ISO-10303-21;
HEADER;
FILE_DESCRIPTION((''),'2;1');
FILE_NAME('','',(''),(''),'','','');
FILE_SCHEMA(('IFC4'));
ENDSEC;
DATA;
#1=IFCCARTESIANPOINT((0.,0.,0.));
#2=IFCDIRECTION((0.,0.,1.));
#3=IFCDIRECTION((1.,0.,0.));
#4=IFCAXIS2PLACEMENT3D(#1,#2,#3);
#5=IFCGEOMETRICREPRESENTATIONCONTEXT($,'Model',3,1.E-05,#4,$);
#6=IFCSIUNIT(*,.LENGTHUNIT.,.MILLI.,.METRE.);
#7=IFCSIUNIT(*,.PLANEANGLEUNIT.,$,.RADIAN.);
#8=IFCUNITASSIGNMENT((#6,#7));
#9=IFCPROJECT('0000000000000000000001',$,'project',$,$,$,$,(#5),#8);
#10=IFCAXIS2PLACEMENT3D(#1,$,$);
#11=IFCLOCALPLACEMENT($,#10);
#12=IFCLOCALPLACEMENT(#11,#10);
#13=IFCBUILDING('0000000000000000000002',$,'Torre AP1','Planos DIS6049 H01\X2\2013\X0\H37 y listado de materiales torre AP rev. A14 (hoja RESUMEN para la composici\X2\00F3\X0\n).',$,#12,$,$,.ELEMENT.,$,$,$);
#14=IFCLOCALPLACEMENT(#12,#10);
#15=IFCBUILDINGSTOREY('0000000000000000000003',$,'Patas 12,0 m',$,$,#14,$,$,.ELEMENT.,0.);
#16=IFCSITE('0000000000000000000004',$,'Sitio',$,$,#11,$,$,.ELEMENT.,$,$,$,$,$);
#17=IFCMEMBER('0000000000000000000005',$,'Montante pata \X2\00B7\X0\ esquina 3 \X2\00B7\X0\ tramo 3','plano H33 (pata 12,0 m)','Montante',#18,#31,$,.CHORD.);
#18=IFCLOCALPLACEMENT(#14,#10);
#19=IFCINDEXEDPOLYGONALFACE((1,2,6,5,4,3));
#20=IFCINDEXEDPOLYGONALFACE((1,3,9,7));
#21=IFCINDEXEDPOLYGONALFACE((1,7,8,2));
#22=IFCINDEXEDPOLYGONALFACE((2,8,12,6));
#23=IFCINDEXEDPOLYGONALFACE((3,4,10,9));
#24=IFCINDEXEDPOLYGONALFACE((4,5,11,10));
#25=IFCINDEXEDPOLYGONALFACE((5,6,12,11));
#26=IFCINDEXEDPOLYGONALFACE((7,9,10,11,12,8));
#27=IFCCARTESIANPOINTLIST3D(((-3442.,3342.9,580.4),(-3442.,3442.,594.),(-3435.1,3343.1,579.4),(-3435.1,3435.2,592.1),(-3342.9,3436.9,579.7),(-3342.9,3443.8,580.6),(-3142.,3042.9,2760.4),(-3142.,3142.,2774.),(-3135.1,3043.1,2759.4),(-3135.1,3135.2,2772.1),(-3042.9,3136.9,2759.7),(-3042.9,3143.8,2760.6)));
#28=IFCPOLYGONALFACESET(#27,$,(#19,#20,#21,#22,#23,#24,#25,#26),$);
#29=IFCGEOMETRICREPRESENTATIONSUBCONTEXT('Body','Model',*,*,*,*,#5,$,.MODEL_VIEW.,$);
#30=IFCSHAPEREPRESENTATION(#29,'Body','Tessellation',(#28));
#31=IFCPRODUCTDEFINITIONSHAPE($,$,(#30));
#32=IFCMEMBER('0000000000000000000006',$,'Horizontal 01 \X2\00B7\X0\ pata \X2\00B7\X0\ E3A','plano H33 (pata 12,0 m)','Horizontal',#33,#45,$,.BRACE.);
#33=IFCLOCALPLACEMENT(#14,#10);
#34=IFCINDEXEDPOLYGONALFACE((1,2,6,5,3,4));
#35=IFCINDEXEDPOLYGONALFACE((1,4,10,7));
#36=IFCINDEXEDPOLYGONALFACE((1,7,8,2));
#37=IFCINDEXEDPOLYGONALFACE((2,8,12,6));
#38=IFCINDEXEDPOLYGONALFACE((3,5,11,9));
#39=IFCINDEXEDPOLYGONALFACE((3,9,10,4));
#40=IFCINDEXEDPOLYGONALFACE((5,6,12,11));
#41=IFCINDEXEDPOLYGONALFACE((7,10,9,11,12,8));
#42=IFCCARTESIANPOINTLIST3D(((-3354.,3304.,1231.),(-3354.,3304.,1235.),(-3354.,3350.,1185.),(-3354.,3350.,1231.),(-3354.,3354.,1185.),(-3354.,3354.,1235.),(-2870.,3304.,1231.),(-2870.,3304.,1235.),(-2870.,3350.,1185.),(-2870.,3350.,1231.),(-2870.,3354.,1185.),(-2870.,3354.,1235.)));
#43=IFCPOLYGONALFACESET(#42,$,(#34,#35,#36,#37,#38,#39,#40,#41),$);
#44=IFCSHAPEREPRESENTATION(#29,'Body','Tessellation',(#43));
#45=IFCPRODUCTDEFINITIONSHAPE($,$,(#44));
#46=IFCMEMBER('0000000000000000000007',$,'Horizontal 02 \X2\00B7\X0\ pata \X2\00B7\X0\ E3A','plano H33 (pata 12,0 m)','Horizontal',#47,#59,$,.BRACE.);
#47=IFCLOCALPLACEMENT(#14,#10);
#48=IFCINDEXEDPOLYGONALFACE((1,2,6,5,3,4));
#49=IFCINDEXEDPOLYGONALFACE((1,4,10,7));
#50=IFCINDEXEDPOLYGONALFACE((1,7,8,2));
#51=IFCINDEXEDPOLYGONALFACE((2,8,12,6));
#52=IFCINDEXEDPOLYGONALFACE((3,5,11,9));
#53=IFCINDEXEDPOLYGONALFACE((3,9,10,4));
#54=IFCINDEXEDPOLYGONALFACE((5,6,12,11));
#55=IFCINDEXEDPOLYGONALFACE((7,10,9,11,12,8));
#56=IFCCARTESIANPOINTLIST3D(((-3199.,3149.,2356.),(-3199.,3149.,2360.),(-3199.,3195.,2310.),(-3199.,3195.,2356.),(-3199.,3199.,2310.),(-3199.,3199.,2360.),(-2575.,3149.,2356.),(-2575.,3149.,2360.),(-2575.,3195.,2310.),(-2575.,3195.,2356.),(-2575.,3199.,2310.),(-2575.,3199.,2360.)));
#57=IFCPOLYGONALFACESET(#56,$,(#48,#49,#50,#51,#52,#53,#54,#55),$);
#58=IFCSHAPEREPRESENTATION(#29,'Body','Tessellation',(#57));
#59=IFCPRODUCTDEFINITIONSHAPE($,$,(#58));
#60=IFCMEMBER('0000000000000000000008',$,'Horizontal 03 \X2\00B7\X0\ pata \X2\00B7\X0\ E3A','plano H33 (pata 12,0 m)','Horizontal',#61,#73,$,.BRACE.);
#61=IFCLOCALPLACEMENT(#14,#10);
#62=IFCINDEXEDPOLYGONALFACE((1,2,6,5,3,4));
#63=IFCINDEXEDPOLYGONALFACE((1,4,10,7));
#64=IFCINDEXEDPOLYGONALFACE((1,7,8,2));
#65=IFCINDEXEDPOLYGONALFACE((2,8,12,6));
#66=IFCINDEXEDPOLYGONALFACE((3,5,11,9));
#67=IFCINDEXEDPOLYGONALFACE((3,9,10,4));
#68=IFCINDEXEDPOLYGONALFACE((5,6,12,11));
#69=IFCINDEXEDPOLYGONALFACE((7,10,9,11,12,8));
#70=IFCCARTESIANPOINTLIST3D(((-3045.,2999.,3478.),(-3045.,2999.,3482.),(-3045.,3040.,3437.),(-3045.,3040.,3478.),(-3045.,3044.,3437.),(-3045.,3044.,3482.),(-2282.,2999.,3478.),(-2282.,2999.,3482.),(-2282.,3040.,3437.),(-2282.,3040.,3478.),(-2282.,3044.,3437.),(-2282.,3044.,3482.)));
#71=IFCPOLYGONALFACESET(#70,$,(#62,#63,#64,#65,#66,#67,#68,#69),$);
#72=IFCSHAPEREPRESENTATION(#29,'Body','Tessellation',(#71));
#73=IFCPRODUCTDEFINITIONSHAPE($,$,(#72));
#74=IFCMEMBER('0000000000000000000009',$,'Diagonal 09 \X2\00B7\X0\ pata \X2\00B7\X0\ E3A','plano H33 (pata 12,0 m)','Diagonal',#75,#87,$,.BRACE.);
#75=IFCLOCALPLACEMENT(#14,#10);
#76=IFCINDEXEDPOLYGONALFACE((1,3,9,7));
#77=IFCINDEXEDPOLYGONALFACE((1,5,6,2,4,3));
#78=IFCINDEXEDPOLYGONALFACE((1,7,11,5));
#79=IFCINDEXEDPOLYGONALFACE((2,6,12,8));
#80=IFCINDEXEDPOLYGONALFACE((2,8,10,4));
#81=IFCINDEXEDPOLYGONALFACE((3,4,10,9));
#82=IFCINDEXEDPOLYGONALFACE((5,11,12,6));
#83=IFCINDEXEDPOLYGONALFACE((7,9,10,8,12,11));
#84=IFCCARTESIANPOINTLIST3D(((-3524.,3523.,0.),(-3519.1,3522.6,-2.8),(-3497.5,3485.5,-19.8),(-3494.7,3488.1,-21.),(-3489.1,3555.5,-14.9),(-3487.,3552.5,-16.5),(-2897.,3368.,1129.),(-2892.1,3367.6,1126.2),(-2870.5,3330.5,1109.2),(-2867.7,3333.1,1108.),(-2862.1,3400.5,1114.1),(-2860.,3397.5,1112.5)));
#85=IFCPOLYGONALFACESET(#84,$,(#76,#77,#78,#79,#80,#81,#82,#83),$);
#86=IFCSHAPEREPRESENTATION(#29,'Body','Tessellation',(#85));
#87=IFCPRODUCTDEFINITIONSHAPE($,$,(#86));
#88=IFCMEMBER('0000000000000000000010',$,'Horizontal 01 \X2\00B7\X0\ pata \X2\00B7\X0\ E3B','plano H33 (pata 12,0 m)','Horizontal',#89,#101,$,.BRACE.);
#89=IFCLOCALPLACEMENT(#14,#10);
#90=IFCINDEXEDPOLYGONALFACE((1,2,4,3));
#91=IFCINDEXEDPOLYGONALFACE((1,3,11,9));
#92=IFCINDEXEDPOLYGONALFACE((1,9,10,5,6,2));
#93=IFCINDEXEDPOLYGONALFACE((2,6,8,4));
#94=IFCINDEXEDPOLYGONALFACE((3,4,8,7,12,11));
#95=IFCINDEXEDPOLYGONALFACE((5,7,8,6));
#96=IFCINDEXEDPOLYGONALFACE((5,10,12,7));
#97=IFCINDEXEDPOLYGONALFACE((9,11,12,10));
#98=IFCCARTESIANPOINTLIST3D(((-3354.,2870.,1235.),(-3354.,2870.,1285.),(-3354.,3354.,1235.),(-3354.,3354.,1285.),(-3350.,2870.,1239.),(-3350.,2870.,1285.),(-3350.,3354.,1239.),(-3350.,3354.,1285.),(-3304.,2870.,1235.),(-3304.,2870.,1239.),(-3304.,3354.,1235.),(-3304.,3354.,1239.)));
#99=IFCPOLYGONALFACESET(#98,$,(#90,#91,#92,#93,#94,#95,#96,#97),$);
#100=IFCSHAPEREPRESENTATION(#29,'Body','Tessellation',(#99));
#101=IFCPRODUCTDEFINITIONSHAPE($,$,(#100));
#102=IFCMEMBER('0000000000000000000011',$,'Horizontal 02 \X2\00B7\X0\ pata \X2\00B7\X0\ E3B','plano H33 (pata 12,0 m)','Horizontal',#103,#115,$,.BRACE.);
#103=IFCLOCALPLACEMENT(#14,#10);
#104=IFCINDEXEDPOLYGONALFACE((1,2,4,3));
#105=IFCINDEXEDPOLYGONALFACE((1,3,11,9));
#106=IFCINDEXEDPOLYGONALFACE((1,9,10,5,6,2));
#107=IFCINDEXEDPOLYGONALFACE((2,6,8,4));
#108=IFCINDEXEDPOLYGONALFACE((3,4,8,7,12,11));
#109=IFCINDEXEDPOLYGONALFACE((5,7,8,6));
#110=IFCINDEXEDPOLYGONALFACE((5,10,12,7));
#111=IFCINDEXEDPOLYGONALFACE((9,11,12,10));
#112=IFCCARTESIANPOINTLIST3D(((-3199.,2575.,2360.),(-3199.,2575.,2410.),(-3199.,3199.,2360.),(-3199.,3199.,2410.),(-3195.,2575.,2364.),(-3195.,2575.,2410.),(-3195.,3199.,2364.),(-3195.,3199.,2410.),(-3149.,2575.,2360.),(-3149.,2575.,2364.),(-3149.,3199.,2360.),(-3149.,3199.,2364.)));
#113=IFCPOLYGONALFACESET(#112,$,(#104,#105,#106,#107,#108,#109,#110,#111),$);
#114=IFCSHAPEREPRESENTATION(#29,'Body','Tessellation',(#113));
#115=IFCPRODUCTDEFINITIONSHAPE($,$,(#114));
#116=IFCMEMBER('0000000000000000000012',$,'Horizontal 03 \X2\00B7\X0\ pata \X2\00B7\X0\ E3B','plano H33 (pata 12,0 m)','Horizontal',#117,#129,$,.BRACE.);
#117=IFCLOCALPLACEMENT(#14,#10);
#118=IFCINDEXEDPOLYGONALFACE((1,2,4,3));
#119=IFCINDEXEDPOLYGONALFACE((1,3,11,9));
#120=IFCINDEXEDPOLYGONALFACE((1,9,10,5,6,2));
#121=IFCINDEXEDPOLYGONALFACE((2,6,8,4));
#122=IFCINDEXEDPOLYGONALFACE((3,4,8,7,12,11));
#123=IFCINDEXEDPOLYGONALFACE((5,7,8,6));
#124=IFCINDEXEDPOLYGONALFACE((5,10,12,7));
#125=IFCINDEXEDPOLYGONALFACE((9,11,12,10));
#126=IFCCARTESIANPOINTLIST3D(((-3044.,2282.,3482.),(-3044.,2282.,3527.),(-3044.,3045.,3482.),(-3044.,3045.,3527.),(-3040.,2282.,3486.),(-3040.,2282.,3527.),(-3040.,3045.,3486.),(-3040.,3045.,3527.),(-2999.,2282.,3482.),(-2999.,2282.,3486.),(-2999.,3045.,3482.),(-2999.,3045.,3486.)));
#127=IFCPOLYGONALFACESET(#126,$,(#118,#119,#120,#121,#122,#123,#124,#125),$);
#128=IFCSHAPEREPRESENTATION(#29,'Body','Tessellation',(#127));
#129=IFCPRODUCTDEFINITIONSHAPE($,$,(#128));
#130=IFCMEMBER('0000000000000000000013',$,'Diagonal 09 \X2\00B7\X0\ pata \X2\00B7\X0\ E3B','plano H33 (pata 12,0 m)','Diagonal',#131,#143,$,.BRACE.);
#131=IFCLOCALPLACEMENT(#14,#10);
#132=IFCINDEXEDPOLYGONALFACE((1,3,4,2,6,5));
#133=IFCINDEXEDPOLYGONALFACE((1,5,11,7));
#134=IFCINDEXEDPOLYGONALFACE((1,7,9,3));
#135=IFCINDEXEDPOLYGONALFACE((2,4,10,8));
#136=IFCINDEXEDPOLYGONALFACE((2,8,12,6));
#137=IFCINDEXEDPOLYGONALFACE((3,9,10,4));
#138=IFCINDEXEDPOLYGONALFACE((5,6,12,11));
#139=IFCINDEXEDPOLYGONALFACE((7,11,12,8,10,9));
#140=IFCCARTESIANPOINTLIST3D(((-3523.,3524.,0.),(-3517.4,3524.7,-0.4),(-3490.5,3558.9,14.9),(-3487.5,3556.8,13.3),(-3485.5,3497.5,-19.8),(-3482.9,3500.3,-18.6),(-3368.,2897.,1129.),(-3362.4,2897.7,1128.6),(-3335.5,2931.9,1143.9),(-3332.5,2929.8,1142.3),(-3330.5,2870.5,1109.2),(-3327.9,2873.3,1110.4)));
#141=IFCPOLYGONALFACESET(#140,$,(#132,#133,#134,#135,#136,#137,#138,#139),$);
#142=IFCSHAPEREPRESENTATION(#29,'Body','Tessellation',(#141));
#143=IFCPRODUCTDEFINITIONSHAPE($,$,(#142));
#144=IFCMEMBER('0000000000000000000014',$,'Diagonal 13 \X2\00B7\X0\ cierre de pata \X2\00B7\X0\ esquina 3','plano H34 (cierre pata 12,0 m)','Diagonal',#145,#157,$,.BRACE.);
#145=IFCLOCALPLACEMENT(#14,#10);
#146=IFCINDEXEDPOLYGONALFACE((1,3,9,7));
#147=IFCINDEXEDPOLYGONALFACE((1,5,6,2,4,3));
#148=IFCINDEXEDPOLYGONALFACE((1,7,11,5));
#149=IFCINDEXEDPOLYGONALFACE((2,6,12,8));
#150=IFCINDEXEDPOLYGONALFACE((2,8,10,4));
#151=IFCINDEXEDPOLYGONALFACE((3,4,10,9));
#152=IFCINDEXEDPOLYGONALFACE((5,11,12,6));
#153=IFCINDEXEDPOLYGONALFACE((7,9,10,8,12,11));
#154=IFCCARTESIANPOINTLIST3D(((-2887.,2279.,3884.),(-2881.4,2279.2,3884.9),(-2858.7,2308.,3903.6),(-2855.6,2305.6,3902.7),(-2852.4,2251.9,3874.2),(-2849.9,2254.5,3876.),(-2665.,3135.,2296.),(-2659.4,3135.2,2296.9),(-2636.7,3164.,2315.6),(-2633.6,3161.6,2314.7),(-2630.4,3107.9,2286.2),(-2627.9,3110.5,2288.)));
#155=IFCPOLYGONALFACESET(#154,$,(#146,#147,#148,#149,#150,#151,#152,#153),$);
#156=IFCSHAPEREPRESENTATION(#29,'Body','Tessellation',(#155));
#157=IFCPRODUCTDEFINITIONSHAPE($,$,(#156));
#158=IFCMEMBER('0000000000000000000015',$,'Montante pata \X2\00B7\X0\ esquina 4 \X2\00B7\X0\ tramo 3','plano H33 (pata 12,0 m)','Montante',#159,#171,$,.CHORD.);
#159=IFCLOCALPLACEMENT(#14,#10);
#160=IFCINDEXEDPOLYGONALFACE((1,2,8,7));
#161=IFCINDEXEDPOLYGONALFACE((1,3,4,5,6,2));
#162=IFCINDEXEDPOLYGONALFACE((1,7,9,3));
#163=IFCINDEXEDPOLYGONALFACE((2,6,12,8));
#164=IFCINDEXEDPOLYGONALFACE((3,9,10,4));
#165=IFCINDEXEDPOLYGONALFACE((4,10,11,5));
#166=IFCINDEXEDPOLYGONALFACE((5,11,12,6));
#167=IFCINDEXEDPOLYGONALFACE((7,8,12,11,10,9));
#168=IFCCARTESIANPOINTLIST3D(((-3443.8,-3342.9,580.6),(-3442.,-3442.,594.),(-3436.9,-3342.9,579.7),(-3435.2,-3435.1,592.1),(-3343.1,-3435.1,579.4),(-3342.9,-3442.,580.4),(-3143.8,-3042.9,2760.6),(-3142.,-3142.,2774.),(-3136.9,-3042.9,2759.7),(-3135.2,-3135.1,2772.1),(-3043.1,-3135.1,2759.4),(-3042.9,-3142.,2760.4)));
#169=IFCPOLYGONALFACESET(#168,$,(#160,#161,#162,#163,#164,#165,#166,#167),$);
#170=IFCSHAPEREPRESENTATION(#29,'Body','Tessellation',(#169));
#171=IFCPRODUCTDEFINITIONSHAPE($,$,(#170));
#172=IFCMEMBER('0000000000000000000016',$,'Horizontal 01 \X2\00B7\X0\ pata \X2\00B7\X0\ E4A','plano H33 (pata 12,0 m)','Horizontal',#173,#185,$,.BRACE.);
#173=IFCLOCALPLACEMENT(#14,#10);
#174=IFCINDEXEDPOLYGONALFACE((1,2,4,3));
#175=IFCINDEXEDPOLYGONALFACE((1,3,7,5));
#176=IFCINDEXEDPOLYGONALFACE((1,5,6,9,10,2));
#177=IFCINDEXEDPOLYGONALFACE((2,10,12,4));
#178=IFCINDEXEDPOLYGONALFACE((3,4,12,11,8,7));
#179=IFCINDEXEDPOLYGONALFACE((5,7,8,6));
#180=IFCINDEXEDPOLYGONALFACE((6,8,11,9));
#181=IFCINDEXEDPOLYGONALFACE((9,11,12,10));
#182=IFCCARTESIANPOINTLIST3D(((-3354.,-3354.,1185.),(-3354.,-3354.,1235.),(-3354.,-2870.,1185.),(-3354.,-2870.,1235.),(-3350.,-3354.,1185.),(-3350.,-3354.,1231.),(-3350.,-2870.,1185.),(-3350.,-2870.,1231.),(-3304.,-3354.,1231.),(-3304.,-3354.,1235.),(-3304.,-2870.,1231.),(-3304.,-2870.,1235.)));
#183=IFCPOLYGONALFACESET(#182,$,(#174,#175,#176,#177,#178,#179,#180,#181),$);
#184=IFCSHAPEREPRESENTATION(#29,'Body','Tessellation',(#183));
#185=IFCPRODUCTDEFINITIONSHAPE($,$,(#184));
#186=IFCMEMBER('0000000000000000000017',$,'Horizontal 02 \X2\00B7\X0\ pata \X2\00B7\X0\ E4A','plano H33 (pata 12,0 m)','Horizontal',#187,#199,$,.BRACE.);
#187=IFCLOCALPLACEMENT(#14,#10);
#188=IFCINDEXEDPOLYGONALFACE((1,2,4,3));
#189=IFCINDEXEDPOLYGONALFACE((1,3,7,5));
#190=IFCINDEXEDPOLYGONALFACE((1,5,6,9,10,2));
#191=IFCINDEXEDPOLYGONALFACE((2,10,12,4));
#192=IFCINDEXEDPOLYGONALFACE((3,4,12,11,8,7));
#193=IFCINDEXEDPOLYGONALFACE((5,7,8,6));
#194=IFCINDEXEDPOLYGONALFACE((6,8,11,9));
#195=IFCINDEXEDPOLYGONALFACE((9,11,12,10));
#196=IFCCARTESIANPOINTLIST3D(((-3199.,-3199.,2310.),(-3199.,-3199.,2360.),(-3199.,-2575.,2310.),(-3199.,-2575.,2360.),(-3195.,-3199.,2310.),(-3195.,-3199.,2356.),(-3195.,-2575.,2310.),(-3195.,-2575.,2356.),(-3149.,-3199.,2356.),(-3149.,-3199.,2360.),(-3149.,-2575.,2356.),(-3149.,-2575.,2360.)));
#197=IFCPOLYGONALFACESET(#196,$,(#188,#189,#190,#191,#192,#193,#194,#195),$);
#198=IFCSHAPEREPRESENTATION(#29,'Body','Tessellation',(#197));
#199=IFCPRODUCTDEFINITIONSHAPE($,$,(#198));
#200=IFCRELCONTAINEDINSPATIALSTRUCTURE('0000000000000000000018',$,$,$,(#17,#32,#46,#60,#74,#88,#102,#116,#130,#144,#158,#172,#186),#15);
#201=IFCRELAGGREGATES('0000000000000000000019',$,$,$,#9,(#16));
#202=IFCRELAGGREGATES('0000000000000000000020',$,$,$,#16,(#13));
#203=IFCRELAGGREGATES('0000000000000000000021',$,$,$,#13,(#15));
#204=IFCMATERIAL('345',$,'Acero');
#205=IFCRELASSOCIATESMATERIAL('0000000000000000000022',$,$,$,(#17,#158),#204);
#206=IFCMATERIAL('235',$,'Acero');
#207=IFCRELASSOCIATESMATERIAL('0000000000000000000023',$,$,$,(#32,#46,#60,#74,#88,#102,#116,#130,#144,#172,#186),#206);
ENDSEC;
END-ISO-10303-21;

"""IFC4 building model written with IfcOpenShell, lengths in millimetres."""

from ifc_helpers import new_model, si_unit, frame, frame_2d, origin, origin_with_axes, place, context, subcontext, project, spatial, l_section, extrude, material, element, save


model = new_model("IFC4")

# Units and contexts
model_context = context("Model", 3, precision=1e-05, world=origin_with_axes())
body_context = subcontext(model_context, "Body", "Model", "MODEL_VIEW")
ifc_project = project(units=[si_unit("LENGTHUNIT", "METRE", prefix="MILLI"), si_unit("PLANEANGLEUNIT", "RADIAN")], contexts=[model_context])

# Site, building, storey
site_placement = place(None, origin())
site = spatial("IfcSite", under=ifc_project, at=site_placement, Name="Sitio", CompositionType="ELEMENT")
building_placement = place(site_placement, origin())
building = spatial("IfcBuilding", under=site, at=building_placement, Name="Torre AP1", Description="Planos DIS6049 H01–H37 y listado de materiales torre AP rev. A14 (hoja RESUMEN para la composición).", CompositionType="ELEMENT")
storey_placement = place(building_placement, origin())
storey = spatial("IfcBuildingStorey", under=building, at=storey_placement, Name="Patas 12,0 m", CompositionType="ELEMENT", Elevation=0.0)

# Members
ifc_material_1 = material(Name="345", Category="Acero")
member_1_placement = place(storey_placement, frame((-3142.0, 3142.0, 2774.0), z_axis=(-0.13508, 0.13508, -0.981584), x_axis=(0.990835, 0.018415, -0.133819)))
element("IfcMember", 1, at=member_1_placement, inside=storey, material=ifc_material_1, Name="Montante pata · esquina 3 · tramo 3", Description="plano H33 (pata 12,0 m)", ObjectType="Montante", PredefinedType="CHORD", context=body_context, shape_type="SweptSolid", body=[
    extrude(l_section(Depth=100.0, Width=100.0, Thickness=7.0, at=frame_2d((50.0, 50.0))), None, (0.0, 0.0, 1.0), 2220.9),
])
ifc_material_2 = material(Name="235", Category="Acero")
member_2_placement = place(storey_placement, frame((-3354.0, 3354.0, 1235.0), z_axis=(1.0, 0.0, 0.0), x_axis=(0.0, -1.0, 0.0)))
element("IfcMember", 2, at=member_2_placement, inside=storey, material=ifc_material_2, Name="Horizontal 01 · pata · E3A", Description="plano H33 (pata 12,0 m)", ObjectType="Horizontal", PredefinedType="BRACE", context=body_context, shape_type="SweptSolid", body=[
    extrude(l_section(Depth=50.0, Width=50.0, Thickness=4.0, at=frame_2d((25.0, 25.0))), None, (0.0, 0.0, 1.0), 484.0),
])
member_3_placement = place(storey_placement, frame((-3199.0, 3199.0, 2360.0), z_axis=(1.0, 0.0, 0.0), x_axis=(0.0, -1.0, 0.0)))
element("IfcMember", 3, at=member_3_placement, inside=storey, material=ifc_material_2, Name="Horizontal 02 · pata · E3A", Description="plano H33 (pata 12,0 m)", ObjectType="Horizontal", PredefinedType="BRACE", context=body_context, shape_type="SweptSolid", body=[
    extrude(l_section(Depth=50.0, Width=50.0, Thickness=4.0, at=frame_2d((25.0, 25.0))), None, (0.0, 0.0, 1.0), 624.0),
])
member_4_placement = place(storey_placement, frame((-3045.0, 3044.0, 3482.0), z_axis=(1.0, 0.0, 0.0), x_axis=(0.0, -1.0, 0.0)))
element("IfcMember", 4, at=member_4_placement, inside=storey, material=ifc_material_2, Name="Horizontal 03 · pata · E3A", Description="plano H33 (pata 12,0 m)", ObjectType="Horizontal", PredefinedType="BRACE", context=body_context, shape_type="SweptSolid", body=[
    extrude(l_section(Depth=45.0, Width=45.0, Thickness=4.0, at=frame_2d((22.5, 22.5))), None, (0.0, 0.0, 1.0), 763.0),
])
member_5_placement = place(storey_placement, frame((-3524.0, 3523.0, 0.0), z_axis=(0.482052, -0.119168, 0.868001), x_axis=(0.529193, -0.749974, -0.396855)))
element("IfcMember", 5, at=member_5_placement, inside=storey, material=ifc_material_2, Name="Diagonal 09 · pata · E3A", Description="plano H33 (pata 12,0 m)", ObjectType="Diagonal", PredefinedType="BRACE", context=body_context, shape_type="SweptSolid", body=[
    extrude(l_section(Depth=50.0, Width=50.0, Thickness=4.0, at=frame_2d((25.0, 25.0))), None, (0.0, 0.0, 1.0), 1300.7),
])
member_6_placement = place(storey_placement, frame((-3354.0, 3354.0, 1235.0), z_axis=(0.0, -1.0, 0.0), x_axis=(1.0, 0.0, 0.0)))
element("IfcMember", 6, at=member_6_placement, inside=storey, material=ifc_material_2, Name="Horizontal 01 · pata · E3B", Description="plano H33 (pata 12,0 m)", ObjectType="Horizontal", PredefinedType="BRACE", context=body_context, shape_type="SweptSolid", body=[
    extrude(l_section(Depth=50.0, Width=50.0, Thickness=4.0, at=frame_2d((25.0, 25.0))), None, (0.0, 0.0, 1.0), 484.0),
])
member_7_placement = place(storey_placement, frame((-3199.0, 3199.0, 2360.0), z_axis=(0.0, -1.0, 0.0), x_axis=(1.0, 0.0, 0.0)))
element("IfcMember", 7, at=member_7_placement, inside=storey, material=ifc_material_2, Name="Horizontal 02 · pata · E3B", Description="plano H33 (pata 12,0 m)", ObjectType="Horizontal", PredefinedType="BRACE", context=body_context, shape_type="SweptSolid", body=[
    extrude(l_section(Depth=50.0, Width=50.0, Thickness=4.0, at=frame_2d((25.0, 25.0))), None, (0.0, 0.0, 1.0), 624.0),
])
member_8_placement = place(storey_placement, frame((-3044.0, 3045.0, 3482.0), z_axis=(0.0, -1.0, 0.0), x_axis=(1.0, 0.0, 0.0)))
element("IfcMember", 8, at=member_8_placement, inside=storey, material=ifc_material_2, Name="Horizontal 03 · pata · E3B", Description="plano H33 (pata 12,0 m)", ObjectType="Horizontal", PredefinedType="BRACE", context=body_context, shape_type="SweptSolid", body=[
    extrude(l_section(Depth=45.0, Width=45.0, Thickness=4.0, at=frame_2d((22.5, 22.5))), None, (0.0, 0.0, 1.0), 763.0),
])
member_9_placement = place(storey_placement, frame((-3523.0, 3524.0, 0.0), z_axis=(0.119168, -0.482052, 0.868001), x_axis=(0.749974, -0.529193, -0.396855)))
element("IfcMember", 9, at=member_9_placement, inside=storey, material=ifc_material_2, Name="Diagonal 09 · pata · E3B", Description="plano H33 (pata 12,0 m)", ObjectType="Diagonal", PredefinedType="BRACE", context=body_context, shape_type="SweptSolid", body=[
    extrude(l_section(Depth=50.0, Width=50.0, Thickness=4.0, at=frame_2d((25.0, 25.0))), None, (0.0, 0.0, 1.0), 1300.7),
])
member_10_placement = place(storey_placement, frame((-2665.0, 3135.0, 2296.0), z_axis=(-0.122137, -0.470944, 0.873667), x_axis=(0.768133, -0.602297, -0.21728)))
element("IfcMember", 10, at=member_10_placement, inside=storey, material=ifc_material_2, Name="Diagonal 13 · cierre de pata · esquina 3", Description="plano H34 (cierre pata 12,0 m)", ObjectType="Diagonal", PredefinedType="BRACE", context=body_context, shape_type="SweptSolid", body=[
    extrude(l_section(Depth=45.0, Width=45.0, Thickness=4.0, at=frame_2d((22.5, 22.5))), None, (0.0, 0.0, 1.0), 1817.6),
])
member_11_placement = place(storey_placement, frame((-3142.0, -3142.0, 2774.0), z_axis=(-0.13508, -0.13508, -0.981584), x_axis=(-0.018415, 0.990835, -0.133819)))
element("IfcMember", 11, at=member_11_placement, inside=storey, material=ifc_material_1, Name="Montante pata · esquina 4 · tramo 3", Description="plano H33 (pata 12,0 m)", ObjectType="Montante", PredefinedType="CHORD", context=body_context, shape_type="SweptSolid", body=[
    extrude(l_section(Depth=100.0, Width=100.0, Thickness=7.0, at=frame_2d((50.0, 50.0))), None, (0.0, 0.0, 1.0), 2220.9),
])
member_12_placement = place(storey_placement, frame((-3354.0, -3354.0, 1235.0), z_axis=(0.0, 1.0, 0.0), x_axis=(1.0, 0.0, 0.0)))
element("IfcMember", 12, at=member_12_placement, inside=storey, material=ifc_material_2, Name="Horizontal 01 · pata · E4A", Description="plano H33 (pata 12,0 m)", ObjectType="Horizontal", PredefinedType="BRACE", context=body_context, shape_type="SweptSolid", body=[
    extrude(l_section(Depth=50.0, Width=50.0, Thickness=4.0, at=frame_2d((25.0, 25.0))), None, (0.0, 0.0, 1.0), 484.0),
])
member_13_placement = place(storey_placement, frame((-3199.0, -3199.0, 2360.0), z_axis=(0.0, 1.0, 0.0), x_axis=(1.0, 0.0, 0.0)))
element("IfcMember", 13, at=member_13_placement, inside=storey, material=ifc_material_2, Name="Horizontal 02 · pata · E4A", Description="plano H33 (pata 12,0 m)", ObjectType="Horizontal", PredefinedType="BRACE", context=body_context, shape_type="SweptSolid", body=[
    extrude(l_section(Depth=50.0, Width=50.0, Thickness=4.0, at=frame_2d((25.0, 25.0))), None, (0.0, 0.0, 1.0), 624.0),
])

save(model, "model.ifc")
